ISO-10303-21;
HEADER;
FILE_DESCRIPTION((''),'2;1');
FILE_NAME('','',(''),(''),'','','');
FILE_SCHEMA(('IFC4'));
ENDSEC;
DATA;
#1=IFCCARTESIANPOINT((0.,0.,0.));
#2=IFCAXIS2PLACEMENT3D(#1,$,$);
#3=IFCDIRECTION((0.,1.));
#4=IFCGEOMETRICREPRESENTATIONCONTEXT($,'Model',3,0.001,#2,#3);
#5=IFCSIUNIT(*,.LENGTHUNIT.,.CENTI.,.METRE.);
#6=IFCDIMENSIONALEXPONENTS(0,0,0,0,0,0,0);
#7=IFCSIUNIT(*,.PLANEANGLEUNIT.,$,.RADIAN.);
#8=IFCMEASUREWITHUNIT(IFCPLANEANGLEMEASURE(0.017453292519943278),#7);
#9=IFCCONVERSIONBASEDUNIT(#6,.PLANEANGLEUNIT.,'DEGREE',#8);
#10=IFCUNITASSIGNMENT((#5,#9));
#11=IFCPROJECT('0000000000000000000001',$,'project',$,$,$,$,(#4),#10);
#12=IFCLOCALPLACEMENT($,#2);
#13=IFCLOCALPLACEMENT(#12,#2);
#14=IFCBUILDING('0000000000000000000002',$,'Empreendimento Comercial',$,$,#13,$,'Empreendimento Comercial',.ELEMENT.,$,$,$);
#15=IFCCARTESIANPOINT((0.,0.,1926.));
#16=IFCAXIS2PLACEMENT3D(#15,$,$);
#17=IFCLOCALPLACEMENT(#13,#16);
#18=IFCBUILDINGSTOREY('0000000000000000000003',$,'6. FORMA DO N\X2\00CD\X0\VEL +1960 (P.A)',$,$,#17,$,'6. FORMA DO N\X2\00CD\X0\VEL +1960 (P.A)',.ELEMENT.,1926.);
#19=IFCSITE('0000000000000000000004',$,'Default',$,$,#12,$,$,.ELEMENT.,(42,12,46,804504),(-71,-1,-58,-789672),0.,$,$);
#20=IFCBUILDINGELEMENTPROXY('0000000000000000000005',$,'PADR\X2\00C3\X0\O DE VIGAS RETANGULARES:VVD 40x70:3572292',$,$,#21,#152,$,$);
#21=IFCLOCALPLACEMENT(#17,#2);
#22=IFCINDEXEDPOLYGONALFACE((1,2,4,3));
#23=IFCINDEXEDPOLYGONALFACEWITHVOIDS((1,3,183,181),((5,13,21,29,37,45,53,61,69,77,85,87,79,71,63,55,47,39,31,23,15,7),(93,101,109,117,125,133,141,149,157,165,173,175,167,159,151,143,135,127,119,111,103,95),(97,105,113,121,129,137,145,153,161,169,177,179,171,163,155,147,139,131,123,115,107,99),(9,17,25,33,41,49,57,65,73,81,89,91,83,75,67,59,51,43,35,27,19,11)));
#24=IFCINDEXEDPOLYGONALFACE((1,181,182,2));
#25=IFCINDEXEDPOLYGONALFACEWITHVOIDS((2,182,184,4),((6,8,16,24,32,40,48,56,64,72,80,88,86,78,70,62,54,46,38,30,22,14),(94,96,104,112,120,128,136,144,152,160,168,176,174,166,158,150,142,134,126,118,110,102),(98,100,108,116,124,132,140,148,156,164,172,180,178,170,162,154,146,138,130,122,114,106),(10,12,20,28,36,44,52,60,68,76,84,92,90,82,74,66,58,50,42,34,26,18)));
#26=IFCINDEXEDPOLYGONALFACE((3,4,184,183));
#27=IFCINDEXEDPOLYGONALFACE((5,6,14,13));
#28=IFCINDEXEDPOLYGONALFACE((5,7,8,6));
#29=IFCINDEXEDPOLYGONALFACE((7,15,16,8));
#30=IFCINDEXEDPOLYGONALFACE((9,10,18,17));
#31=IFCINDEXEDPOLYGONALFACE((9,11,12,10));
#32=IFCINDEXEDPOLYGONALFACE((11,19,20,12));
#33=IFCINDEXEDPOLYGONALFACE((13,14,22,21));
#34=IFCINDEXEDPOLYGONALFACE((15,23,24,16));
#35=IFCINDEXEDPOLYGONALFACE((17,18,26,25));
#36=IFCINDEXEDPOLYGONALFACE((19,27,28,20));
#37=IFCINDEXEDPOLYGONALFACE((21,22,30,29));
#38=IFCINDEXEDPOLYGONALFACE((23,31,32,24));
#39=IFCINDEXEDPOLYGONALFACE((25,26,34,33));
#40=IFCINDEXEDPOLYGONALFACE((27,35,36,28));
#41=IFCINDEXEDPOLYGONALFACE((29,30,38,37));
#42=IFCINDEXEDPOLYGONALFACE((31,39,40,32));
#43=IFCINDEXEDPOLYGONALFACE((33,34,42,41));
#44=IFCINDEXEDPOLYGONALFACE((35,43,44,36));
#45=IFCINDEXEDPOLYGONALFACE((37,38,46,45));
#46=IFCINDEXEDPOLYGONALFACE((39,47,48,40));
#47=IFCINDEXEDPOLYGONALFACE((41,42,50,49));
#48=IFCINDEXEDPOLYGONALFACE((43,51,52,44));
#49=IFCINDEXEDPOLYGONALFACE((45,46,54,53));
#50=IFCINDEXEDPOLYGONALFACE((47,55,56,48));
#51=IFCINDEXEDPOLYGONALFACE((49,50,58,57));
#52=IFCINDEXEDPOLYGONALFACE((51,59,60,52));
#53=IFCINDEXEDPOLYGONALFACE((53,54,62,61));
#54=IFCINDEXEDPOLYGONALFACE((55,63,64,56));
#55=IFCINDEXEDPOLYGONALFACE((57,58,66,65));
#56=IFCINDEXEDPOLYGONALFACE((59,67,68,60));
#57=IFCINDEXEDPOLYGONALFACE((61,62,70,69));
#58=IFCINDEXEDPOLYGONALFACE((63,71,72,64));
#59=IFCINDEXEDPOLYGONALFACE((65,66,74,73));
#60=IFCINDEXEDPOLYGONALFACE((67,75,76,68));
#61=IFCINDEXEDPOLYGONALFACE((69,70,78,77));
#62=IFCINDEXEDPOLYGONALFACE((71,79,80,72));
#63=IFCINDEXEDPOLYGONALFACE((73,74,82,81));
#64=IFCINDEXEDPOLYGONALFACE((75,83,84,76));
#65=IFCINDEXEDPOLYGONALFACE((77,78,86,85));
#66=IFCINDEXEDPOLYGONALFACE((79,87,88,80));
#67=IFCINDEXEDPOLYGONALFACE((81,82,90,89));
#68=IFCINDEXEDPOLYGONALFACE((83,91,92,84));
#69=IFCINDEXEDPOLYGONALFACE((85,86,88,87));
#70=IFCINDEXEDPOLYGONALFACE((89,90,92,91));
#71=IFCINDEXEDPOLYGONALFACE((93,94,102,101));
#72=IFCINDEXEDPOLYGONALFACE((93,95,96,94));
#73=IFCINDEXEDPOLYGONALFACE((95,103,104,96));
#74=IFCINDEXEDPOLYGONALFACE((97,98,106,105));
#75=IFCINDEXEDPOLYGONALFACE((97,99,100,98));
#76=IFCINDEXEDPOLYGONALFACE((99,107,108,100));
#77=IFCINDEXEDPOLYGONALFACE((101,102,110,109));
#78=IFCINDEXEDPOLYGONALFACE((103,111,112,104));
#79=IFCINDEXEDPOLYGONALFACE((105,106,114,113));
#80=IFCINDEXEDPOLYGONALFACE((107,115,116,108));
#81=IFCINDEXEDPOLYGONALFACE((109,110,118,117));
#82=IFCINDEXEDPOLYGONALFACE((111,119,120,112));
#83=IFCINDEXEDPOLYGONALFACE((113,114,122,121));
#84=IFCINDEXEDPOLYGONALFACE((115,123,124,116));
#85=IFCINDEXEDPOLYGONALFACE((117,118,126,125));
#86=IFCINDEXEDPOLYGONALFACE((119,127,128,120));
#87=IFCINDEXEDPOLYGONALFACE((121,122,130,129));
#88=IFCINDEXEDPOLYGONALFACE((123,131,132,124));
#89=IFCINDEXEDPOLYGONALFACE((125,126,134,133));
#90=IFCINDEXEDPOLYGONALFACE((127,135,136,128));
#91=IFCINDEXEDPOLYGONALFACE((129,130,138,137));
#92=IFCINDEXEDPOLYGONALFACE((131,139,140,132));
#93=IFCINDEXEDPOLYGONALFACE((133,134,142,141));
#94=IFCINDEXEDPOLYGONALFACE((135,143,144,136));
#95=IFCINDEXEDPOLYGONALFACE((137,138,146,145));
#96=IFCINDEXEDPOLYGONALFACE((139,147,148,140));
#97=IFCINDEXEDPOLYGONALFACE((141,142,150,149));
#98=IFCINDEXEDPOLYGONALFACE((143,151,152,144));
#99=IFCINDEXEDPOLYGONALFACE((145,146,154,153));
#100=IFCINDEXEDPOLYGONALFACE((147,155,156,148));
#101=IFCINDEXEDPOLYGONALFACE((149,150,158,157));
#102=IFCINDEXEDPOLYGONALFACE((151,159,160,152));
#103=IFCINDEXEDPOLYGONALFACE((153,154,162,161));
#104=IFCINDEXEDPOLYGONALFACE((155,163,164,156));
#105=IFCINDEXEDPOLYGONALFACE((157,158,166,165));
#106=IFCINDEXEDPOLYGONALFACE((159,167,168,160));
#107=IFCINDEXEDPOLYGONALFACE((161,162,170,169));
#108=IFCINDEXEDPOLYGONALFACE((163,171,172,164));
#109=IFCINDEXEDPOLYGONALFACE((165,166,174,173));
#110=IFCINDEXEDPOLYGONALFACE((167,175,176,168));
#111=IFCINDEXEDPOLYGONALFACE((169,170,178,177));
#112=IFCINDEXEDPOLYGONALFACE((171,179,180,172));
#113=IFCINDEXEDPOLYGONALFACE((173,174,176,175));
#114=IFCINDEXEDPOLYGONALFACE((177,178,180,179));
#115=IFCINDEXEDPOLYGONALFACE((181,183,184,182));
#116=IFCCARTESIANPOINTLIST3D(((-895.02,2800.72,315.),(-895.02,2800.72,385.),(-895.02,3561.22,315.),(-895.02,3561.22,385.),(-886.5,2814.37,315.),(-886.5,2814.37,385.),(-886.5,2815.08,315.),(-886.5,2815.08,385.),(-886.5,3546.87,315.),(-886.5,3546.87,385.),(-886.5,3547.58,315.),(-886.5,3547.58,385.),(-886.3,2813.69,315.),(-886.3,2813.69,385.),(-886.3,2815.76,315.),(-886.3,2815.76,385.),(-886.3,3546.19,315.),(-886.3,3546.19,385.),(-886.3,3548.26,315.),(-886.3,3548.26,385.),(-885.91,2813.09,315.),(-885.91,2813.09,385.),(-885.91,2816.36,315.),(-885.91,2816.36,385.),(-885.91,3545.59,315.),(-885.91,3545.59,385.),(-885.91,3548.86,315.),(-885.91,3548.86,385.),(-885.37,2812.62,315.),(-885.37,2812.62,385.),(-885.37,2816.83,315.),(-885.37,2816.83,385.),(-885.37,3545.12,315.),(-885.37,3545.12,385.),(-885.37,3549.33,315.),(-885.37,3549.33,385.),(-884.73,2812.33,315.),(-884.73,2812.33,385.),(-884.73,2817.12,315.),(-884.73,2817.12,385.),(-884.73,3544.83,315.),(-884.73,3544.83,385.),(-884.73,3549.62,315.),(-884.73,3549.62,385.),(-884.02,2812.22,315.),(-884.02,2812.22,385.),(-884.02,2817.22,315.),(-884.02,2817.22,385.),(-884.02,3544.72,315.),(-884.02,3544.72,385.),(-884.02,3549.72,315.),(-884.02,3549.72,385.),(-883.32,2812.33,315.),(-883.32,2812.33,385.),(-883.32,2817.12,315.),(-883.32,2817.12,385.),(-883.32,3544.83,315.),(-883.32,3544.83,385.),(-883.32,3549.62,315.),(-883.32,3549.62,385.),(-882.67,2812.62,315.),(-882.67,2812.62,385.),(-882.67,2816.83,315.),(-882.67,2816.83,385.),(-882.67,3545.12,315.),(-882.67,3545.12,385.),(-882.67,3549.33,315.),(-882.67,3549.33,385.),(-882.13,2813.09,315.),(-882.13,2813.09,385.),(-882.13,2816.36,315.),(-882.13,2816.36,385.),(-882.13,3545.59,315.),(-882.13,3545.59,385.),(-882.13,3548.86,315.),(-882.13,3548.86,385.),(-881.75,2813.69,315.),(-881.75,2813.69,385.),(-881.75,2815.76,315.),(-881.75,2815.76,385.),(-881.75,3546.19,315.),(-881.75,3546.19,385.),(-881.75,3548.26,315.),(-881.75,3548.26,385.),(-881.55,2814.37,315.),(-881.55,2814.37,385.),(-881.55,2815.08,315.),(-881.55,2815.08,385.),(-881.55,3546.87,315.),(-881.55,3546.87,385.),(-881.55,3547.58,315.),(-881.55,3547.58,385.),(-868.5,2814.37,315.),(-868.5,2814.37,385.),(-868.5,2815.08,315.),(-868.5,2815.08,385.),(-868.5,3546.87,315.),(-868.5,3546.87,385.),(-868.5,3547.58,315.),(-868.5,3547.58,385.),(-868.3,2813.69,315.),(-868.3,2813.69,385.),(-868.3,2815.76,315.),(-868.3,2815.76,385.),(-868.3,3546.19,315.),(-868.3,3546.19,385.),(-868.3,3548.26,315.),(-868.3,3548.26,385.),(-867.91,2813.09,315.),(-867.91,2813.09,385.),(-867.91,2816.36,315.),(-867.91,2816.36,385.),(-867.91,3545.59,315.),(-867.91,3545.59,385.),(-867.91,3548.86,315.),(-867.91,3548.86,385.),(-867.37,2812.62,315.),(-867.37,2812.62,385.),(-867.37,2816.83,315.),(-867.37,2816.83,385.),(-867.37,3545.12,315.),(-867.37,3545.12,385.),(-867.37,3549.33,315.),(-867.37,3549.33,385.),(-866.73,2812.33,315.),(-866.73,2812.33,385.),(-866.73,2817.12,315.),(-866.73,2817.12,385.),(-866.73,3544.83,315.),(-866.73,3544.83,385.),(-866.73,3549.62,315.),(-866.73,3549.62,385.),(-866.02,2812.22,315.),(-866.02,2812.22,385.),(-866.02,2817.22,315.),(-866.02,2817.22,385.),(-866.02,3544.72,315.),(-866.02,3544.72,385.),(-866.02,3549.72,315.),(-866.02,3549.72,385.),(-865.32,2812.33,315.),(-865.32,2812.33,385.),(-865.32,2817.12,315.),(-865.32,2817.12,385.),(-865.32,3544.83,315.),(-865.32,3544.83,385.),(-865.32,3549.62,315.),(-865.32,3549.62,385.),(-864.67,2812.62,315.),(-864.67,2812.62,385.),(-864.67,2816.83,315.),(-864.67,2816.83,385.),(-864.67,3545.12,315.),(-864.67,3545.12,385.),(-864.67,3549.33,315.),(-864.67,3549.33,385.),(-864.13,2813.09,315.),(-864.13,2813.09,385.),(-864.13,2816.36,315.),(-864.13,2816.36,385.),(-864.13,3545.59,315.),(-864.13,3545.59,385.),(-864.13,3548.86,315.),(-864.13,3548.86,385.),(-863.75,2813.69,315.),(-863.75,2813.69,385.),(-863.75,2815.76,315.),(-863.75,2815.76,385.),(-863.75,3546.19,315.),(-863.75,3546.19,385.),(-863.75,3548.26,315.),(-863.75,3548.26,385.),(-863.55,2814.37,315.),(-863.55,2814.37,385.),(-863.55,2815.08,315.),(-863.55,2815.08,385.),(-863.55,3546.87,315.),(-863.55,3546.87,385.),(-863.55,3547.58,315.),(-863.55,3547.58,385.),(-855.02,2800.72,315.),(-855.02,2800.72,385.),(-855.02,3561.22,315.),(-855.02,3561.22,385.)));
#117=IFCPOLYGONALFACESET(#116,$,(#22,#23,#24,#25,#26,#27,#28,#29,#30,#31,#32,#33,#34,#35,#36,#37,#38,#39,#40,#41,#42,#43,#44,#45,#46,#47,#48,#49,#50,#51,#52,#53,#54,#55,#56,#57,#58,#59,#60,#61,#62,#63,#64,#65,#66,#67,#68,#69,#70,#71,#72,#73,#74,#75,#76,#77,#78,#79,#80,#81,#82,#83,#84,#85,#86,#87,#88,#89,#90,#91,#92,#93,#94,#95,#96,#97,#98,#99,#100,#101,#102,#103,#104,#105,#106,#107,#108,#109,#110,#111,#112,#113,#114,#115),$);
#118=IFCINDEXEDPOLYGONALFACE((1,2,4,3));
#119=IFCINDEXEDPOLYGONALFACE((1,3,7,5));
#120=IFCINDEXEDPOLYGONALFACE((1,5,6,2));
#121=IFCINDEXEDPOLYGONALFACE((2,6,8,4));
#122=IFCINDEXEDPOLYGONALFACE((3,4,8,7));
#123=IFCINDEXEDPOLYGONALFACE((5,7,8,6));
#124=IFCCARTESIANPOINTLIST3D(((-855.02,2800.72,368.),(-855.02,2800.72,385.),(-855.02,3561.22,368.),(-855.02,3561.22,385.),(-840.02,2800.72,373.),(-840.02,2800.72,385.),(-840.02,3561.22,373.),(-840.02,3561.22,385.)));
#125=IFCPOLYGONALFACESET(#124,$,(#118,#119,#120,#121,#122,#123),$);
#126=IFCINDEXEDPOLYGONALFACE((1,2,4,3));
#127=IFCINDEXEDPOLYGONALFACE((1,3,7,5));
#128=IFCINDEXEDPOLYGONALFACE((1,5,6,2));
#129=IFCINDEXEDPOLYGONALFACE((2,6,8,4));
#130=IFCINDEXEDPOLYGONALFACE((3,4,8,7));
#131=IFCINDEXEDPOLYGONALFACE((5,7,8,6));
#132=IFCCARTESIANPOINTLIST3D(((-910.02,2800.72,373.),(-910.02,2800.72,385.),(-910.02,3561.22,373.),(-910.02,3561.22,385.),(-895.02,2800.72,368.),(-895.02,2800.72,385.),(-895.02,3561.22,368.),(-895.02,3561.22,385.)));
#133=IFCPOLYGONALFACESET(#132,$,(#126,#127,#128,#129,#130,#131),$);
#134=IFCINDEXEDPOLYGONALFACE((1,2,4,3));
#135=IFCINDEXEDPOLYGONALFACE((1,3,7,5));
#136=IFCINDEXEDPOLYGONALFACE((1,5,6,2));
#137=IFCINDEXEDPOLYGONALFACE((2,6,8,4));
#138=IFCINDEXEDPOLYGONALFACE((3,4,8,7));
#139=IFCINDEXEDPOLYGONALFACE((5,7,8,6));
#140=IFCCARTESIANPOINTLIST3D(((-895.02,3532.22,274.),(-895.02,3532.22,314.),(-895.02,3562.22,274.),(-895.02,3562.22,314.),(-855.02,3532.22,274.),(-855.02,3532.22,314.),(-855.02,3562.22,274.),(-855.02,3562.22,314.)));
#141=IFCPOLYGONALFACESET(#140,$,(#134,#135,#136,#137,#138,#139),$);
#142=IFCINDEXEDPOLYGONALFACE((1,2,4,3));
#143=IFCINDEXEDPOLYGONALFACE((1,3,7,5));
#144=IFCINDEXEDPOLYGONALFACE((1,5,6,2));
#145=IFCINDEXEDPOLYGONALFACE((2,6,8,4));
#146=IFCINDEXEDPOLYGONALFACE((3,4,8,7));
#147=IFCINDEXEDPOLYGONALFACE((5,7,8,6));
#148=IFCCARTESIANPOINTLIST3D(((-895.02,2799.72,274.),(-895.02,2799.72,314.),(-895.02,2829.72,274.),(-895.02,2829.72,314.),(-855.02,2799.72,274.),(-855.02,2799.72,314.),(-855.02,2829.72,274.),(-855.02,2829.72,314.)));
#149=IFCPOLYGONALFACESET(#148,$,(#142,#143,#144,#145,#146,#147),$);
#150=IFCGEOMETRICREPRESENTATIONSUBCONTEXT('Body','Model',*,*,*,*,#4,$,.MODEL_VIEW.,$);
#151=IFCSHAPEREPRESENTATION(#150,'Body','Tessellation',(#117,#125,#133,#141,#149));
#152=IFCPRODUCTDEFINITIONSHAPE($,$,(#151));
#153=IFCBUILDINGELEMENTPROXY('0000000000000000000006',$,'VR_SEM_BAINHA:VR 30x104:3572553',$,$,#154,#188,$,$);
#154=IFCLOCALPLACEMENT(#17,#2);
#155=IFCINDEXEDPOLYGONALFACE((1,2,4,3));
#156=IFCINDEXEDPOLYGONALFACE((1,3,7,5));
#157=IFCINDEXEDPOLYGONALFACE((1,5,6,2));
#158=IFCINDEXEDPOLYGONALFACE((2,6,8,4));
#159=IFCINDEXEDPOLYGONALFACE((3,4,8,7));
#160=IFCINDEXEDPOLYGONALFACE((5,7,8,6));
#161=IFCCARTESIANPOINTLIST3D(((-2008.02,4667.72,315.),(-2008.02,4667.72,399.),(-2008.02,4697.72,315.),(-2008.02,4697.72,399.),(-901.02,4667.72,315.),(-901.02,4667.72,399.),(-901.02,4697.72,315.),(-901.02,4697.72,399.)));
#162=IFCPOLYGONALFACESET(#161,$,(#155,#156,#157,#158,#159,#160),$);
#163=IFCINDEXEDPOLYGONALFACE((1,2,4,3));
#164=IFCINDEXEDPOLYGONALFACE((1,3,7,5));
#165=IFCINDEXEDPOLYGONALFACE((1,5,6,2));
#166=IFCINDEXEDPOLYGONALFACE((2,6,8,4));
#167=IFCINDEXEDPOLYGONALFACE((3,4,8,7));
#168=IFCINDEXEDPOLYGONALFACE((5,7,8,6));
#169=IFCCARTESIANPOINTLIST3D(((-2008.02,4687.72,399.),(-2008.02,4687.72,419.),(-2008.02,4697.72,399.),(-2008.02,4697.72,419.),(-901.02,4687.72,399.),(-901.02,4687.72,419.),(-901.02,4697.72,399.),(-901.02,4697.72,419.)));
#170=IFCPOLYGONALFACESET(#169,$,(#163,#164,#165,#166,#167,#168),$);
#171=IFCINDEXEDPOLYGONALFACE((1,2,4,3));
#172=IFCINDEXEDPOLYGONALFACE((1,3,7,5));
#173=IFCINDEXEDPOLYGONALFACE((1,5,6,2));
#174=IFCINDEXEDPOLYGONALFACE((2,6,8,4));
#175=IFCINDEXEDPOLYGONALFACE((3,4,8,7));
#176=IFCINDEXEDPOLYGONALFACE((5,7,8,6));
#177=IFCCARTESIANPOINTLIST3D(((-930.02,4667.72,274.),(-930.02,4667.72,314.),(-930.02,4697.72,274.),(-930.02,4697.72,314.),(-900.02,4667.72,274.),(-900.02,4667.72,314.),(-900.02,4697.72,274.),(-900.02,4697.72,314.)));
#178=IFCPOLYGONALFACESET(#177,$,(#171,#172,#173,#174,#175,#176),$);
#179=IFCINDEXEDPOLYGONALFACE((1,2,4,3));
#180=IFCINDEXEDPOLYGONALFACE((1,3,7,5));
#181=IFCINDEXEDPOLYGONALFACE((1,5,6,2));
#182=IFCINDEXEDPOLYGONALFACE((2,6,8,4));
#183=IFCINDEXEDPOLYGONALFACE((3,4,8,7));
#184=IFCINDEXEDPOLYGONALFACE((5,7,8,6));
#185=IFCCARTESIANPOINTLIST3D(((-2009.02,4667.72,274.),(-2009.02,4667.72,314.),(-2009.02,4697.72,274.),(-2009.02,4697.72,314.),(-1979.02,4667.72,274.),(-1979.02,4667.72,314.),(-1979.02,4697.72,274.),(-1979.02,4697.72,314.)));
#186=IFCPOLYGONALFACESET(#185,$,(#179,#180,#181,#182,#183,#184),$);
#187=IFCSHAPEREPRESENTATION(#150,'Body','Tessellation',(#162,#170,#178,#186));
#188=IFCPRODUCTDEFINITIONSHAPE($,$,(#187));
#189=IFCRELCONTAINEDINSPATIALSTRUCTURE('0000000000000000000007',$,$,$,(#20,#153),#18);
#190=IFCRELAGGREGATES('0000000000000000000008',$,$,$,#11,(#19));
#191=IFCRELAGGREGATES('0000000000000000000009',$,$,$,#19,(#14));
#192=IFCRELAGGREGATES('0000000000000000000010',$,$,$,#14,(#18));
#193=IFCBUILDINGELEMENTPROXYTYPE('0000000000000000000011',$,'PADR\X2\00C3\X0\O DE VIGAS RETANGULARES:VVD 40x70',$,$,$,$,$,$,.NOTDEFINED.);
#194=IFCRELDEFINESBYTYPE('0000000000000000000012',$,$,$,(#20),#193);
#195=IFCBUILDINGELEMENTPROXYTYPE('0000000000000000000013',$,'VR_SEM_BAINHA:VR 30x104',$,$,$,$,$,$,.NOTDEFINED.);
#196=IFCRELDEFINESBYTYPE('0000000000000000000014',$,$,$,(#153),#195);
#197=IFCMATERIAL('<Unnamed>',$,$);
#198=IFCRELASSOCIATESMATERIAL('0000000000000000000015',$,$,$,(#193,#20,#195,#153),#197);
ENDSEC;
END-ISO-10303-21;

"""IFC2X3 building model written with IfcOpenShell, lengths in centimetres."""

from ifc_helpers import new_model, entity, si_unit, converted_unit, direction, frame, frame_2d, origin, origin_2d_with_axis, place, context, subcontext, project, spatial, polyline, circle_curve, parameter, trimmed, segment, composite_curve, rectangle, outline, extrude, source, transform, mapped, material, type_object, type_shapes, element, save


model = new_model("IFC2X3")

# Units and contexts
model_context = context("Model", 3, precision=0.001, world=origin(), true_north=direction((0.0, 1.0)))
body_context = subcontext(model_context, "Body", "Model", "MODEL_VIEW")
ifc_project = project(units=[si_unit("LENGTHUNIT", "METRE", prefix="CENTI"), converted_unit("PLANEANGLEUNIT", "DEGREE", entity("IfcPlaneAngleMeasure", 0.017453292519943278), si_unit("PLANEANGLEUNIT", "RADIAN"), dimensions=[0, 0, 0, 0, 0, 0, 0])], contexts=[model_context])

# Site, building, storey
site_placement = place(None, origin())
site = spatial("IfcSite", under=ifc_project, at=site_placement, Name="Default", CompositionType="ELEMENT", RefLatitude=(42, 12, 46, 804504), RefLongitude=(-71, -1, -58, -789672), RefElevation=0.0)
building_placement = place(site_placement, origin())
building = spatial("IfcBuilding", under=site, at=building_placement, Name="Empreendimento Comercial", LongName="Empreendimento Comercial", CompositionType="ELEMENT")
storey_placement = place(building_placement, frame((0.0, 0.0, 1926.0)))
storey = spatial("IfcBuildingStorey", under=building, at=storey_placement, Name="6. FORMA DO NÍVEL +1960 (P.A)", LongName="6. FORMA DO NÍVEL +1960 (P.A)", CompositionType="ELEMENT", Elevation=1926.0)

# Building element proxies
ifc_material = material(Name="<Unnamed>")
building_element_proxy_type_1 = type_object("IfcBuildingElementProxyType", Name="PADRÃO DE VIGAS RETANGULARES:VVD 40x70", PredefinedType="NOTDEFINED", material=ifc_material)
shared_shape_1 = source(origin(), body_context, "Body", "SweptSolid", [
    extrude(outline(polyline([(-20.0, -380.25), (20.0, -380.25), (20.0, 380.25), (-20.0, 380.25), (-20.0, -380.25)]), holes=[composite_curve([segment(trimmed(circle_curve(frame_2d((-9.0, -366.25), x_axis=(0.0, -1.0)), 2.5), [parameter(0.0)], [parameter(180.0)], True, "PARAMETER"), False, "CONTINUOUS"), segment(trimmed(circle_curve(frame_2d((-9.0, -366.25), x_axis=(0.0, -1.0)), 2.5), [parameter(180.0)], [parameter(0.0)], True, "PARAMETER"), False, "CONTINUOUS")], self_intersect=False), composite_curve([segment(trimmed(circle_curve(frame_2d((9.0, -366.25), x_axis=(0.0, -1.0)), 2.5), [parameter(0.0)], [parameter(180.0)], True, "PARAMETER"), False, "CONTINUOUS"), segment(trimmed(circle_curve(frame_2d((9.0, -366.25), x_axis=(0.0, -1.0)), 2.5), [parameter(180.0)], [parameter(0.0)], True, "PARAMETER"), False, "CONTINUOUS")], self_intersect=False), composite_curve([segment(trimmed(circle_curve(frame_2d((9.0, 366.25), x_axis=(0.0, -1.0)), 2.5), [parameter(0.0)], [parameter(180.0)], True, "PARAMETER"), False, "CONTINUOUS"), segment(trimmed(circle_curve(frame_2d((9.0, 366.25), x_axis=(0.0, -1.0)), 2.5), [parameter(180.0)], [parameter(0.0)], True, "PARAMETER"), False, "CONTINUOUS")], self_intersect=False), composite_curve([segment(trimmed(circle_curve(frame_2d((-9.0, 366.25), x_axis=(0.0, -1.0)), 2.5), [parameter(0.0)], [parameter(180.0)], True, "PARAMETER"), False, "CONTINUOUS"), segment(trimmed(circle_curve(frame_2d((-9.0, 366.25), x_axis=(0.0, -1.0)), 2.5), [parameter(180.0)], [parameter(0.0)], True, "PARAMETER"), False, "CONTINUOUS")], self_intersect=False)]), frame((-875.02, 3180.97, 2241.0)), (0.0, 0.0, 1.0), 70.0),
    extrude(outline(polyline([(-7.25, -7.5), (4.75, -7.5), (9.75, 7.5), (-7.25, 7.5), (-7.25, -7.5)])), frame((-847.52, 2800.72, 2303.75), z_axis=(0.0, 1.0, 0.0), x_axis=(0.0, 0.0, -1.0)), (0.0, 0.0, 1.0), 760.5),
    extrude(outline(polyline([(-7.5, -7.25), (7.5, -7.25), (7.5, 9.75), (-7.5, 4.75), (-7.5, -7.25)])), frame((-902.52, 2800.72, 2303.75), z_axis=(0.0, 1.0, 0.0), x_axis=(1.0, 0.0, 0.0)), (0.0, 0.0, 1.0), 760.5),
    extrude(rectangle(XDim=30.0, YDim=40.0, at=frame_2d((0.0, 0.0), x_axis=(1.0, 0.0))), frame((-875.02, 3547.22, 2200.0), z_axis=(0.0, 0.0, 1.0), x_axis=(0.0, 1.0, 0.0)), (0.0, 0.0, 1.0), 40.0),
    extrude(rectangle(XDim=30.0, YDim=40.0, at=origin_2d_with_axis()), frame((-875.02, 2814.72, 2200.0), z_axis=(0.0, 0.0, 1.0), x_axis=(0.0, 1.0, 0.0)), (0.0, 0.0, 1.0), 40.0),
])
type_shapes(building_element_proxy_type_1, [shared_shape_1])
proxy_1_placement = place(storey_placement, frame((0.0, 0.0, -1926.0)))
element("IfcBuildingElementProxy", 1, at=proxy_1_placement, inside=storey, type_object=building_element_proxy_type_1, material=ifc_material, Name="PADRÃO DE VIGAS RETANGULARES:VVD 40x70:3572292", context=body_context, shape_type="MappedRepresentation", body=[
    mapped(shared_shape_1, transform((0.0, 0.0, 0.0), scale=1.0)),
])
building_element_proxy_type_2 = type_object("IfcBuildingElementProxyType", Name="VR_SEM_BAINHA:VR 30x104", PredefinedType="NOTDEFINED", material=ifc_material)
shared_shape_2 = source(origin(), body_context, "Body", "SweptSolid", [
    extrude(rectangle(XDim=30.0, YDim=1107.0, at=frame_2d((0.0, 0.0), x_axis=(1.0, 0.0))), frame((-1454.52, 4682.72, 2241.0), z_axis=(0.0, 0.0, 1.0), x_axis=(0.0, -1.0, 0.0)), (0.0, 0.0, 1.0), 84.0),
    extrude(rectangle(XDim=10.0, YDim=1107.0, at=frame_2d((0.0, 0.0), x_axis=(1.0, 0.0))), frame((-1454.52, 4692.72, 2325.0), z_axis=(0.0, 0.0, 1.0), x_axis=(0.0, -1.0, 0.0)), (0.0, 0.0, 1.0), 20.0),
    extrude(rectangle(XDim=30.0, YDim=30.0, at=frame_2d((0.0, 0.0), x_axis=(1.0, 0.0))), frame((-915.02, 4682.72, 2200.0)), (0.0, 0.0, 1.0), 40.0),
    extrude(rectangle(XDim=30.0, YDim=30.0, at=origin_2d_with_axis()), frame((-1994.02, 4682.72, 2200.0)), (0.0, 0.0, 1.0), 40.0),
])
type_shapes(building_element_proxy_type_2, [shared_shape_2])
proxy_2_placement = place(storey_placement, frame((0.0, 0.0, -1926.0)))
element("IfcBuildingElementProxy", 2, at=proxy_2_placement, inside=storey, type_object=building_element_proxy_type_2, material=ifc_material, Name="VR_SEM_BAINHA:VR 30x104:3572553", context=body_context, shape_type="MappedRepresentation", body=[
    mapped(shared_shape_2, transform((0.0, 0.0, 0.0), scale=1.0)),
])

save(model, "model.ifc")
